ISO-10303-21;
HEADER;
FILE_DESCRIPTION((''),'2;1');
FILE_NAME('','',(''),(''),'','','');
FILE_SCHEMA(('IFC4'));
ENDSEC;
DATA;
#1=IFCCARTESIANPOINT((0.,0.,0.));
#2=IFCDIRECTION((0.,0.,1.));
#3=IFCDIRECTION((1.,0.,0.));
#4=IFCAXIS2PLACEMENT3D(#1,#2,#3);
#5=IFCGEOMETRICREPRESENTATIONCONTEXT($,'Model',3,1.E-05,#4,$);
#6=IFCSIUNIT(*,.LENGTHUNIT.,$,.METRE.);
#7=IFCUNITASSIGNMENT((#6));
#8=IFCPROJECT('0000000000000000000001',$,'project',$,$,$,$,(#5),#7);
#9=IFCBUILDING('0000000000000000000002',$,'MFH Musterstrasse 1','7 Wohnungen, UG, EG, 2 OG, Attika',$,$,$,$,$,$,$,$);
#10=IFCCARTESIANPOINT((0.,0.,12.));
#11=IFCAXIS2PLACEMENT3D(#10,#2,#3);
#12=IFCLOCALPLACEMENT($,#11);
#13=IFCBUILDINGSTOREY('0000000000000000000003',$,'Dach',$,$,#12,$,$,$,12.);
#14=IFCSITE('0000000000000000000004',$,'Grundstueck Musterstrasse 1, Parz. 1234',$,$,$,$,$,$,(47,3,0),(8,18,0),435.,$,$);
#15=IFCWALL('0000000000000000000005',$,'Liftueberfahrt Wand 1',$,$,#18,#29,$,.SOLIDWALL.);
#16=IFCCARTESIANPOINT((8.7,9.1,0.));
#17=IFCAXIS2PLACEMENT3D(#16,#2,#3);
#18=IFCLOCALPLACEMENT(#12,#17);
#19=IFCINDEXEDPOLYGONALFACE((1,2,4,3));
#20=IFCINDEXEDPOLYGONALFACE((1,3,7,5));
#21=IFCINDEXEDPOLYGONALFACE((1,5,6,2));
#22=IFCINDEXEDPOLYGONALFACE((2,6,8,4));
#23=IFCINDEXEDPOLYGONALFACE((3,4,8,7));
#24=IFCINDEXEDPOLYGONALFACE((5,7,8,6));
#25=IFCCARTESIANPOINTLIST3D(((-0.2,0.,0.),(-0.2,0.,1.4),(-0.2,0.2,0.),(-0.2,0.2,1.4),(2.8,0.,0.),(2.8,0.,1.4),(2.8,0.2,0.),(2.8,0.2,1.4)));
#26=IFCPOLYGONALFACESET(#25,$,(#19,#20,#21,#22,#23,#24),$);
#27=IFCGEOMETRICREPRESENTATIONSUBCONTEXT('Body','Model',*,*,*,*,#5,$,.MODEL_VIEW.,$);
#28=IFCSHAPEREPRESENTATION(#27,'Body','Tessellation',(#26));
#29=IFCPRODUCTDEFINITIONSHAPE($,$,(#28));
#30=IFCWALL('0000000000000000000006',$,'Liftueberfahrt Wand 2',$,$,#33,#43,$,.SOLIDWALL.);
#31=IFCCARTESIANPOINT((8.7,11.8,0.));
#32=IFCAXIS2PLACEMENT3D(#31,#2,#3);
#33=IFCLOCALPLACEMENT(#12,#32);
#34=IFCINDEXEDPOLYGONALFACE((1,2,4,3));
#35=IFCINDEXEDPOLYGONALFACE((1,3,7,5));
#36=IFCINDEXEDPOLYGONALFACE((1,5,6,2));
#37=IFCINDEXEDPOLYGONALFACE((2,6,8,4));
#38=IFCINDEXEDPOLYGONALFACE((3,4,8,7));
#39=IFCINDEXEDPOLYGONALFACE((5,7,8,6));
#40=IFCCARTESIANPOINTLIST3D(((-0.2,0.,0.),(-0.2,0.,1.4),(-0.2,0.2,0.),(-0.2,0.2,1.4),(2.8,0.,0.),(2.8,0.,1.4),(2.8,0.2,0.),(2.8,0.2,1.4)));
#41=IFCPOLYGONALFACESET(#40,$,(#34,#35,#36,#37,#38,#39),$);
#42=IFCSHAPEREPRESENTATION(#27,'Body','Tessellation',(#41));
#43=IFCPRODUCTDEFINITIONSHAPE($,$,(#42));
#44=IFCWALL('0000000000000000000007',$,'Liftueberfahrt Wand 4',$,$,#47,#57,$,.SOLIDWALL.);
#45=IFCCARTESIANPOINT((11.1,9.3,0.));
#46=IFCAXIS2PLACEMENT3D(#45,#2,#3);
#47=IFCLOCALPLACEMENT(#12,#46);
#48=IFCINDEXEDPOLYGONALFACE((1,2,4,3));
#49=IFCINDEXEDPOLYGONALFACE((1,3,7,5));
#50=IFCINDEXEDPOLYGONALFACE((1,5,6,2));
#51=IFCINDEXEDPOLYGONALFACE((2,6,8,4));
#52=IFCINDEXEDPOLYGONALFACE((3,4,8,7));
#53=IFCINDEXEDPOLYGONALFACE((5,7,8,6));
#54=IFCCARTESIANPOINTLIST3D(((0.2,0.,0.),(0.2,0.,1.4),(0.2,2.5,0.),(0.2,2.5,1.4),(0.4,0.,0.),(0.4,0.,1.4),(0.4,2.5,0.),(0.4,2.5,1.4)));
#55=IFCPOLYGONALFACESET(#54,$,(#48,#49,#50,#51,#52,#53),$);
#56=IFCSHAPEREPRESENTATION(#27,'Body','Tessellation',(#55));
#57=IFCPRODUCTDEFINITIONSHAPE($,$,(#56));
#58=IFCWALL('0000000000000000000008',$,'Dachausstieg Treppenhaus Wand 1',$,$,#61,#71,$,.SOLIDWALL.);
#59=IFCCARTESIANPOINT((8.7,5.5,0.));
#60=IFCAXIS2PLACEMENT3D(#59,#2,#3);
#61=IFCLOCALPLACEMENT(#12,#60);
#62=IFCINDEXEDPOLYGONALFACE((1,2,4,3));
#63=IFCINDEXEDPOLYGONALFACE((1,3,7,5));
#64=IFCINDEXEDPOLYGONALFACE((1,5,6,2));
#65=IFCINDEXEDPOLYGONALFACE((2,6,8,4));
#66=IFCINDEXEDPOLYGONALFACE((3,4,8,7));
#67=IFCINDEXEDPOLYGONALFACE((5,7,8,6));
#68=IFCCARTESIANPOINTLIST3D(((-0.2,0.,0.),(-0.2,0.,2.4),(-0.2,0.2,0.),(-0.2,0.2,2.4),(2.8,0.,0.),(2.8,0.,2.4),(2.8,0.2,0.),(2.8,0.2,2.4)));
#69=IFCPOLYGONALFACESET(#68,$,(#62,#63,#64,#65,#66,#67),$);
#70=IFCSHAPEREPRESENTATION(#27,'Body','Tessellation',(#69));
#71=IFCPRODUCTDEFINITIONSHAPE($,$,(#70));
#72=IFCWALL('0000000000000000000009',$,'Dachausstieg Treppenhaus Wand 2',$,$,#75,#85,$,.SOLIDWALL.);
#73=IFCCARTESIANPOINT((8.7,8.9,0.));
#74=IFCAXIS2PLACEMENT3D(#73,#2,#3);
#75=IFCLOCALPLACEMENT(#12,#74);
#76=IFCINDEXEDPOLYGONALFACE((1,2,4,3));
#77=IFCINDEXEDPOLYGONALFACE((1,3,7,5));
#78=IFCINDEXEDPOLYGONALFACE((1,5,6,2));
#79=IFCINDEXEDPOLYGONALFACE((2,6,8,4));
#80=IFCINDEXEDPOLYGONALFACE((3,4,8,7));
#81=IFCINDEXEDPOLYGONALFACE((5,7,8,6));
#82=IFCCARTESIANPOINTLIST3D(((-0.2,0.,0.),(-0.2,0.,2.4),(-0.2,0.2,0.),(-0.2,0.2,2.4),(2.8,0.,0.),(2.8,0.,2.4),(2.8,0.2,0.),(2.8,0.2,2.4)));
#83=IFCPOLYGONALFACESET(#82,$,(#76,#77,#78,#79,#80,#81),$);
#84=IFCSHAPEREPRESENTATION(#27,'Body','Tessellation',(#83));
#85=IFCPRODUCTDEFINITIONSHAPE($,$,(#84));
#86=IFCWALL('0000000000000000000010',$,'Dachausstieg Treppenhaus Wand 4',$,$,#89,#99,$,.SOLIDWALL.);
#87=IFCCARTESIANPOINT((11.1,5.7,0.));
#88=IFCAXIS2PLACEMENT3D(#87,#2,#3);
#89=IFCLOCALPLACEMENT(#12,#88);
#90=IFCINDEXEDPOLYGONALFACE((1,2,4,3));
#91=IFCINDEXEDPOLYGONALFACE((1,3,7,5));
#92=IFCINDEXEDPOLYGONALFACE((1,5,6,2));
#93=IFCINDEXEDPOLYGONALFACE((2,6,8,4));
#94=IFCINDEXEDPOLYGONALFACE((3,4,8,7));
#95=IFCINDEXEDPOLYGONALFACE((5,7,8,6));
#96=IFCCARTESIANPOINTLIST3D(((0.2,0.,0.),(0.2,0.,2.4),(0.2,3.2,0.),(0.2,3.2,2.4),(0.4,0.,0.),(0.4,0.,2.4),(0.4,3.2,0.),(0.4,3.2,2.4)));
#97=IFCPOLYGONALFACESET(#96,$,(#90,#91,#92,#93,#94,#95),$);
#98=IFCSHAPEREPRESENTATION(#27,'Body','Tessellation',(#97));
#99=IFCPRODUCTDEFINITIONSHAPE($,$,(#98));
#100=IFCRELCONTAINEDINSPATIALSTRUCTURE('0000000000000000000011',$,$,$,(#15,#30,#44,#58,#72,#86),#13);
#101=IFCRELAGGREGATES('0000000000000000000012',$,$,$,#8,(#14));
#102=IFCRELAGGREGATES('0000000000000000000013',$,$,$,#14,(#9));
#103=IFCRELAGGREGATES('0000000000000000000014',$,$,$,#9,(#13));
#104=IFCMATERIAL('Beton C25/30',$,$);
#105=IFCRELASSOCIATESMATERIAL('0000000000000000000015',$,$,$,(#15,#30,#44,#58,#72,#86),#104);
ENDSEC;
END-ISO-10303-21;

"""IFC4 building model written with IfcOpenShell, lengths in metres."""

from ifc_helpers import new_model, si_unit, frame, frame_2d, origin_with_axes, place, context, subcontext, project, spatial, rectangle, extrude, material, element, save


model = new_model("IFC4")

# Units and contexts
model_context = context("Model", 3, precision=1e-05, world=origin_with_axes())
body_context = subcontext(model_context, "Body", "Model", "MODEL_VIEW")
ifc_project = project(units=[si_unit("LENGTHUNIT", "METRE")], contexts=[model_context])

# Site, building, storey
site = spatial("IfcSite", under=ifc_project, Name="Grundstueck Musterstrasse 1, Parz. 1234", RefLatitude=(47, 3, 0), RefLongitude=(8, 18, 0), RefElevation=435.0)
building = spatial("IfcBuilding", under=site, Name="MFH Musterstrasse 1", Description="7 Wohnungen, UG, EG, 2 OG, Attika")
storey_placement = place(None, frame((0.0, 0.0, 12.0), z_axis=(0.0, 0.0, 1.0), x_axis=(1.0, 0.0, 0.0)))
storey = spatial("IfcBuildingStorey", under=building, at=storey_placement, Name="Dach", Elevation=12.0)

# Shared definitions
ifc_material_1 = material(Name="Beton C25/30")

# Walls
for number, where, z_axis, x_axis, name in (
    (1, (8.7, 9.1, 0.0), (0.0, 0.0, 1.0), (1.0, 0.0, 0.0), "Liftueberfahrt Wand 1"),
    (2, (8.7, 11.8, 0.0), (0.0, 0.0, 1.0), (1.0, 0.0, 0.0), "Liftueberfahrt Wand 2"),
):
    element("IfcWall", number, at=place(storey_placement, frame(where, z_axis=z_axis, x_axis=x_axis)), inside=storey, material=ifc_material_1, Name=name, PredefinedType="SOLIDWALL", context=body_context, shape_type="SweptSolid", body=[
        extrude(rectangle(XDim=3.0, YDim=0.2, at=frame_2d((1.3, 0.1))), origin_with_axes(), (0.0, 0.0, 1.0), 1.4),
    ])
wall_1_placement = place(storey_placement, frame((11.1, 9.3, 0.0), z_axis=(0.0, 0.0, 1.0), x_axis=(1.0, 0.0, 0.0)))
element("IfcWall", 3, at=wall_1_placement, inside=storey, material=ifc_material_1, Name="Liftueberfahrt Wand 4", PredefinedType="SOLIDWALL", context=body_context, shape_type="SweptSolid", body=[
    extrude(rectangle(XDim=0.2, YDim=2.5, at=frame_2d((0.3, 1.25))), origin_with_axes(), (0.0, 0.0, 1.0), 1.4),
])
for number, where, z_axis, x_axis, name in (
    (4, (8.7, 5.5, 0.0), (0.0, 0.0, 1.0), (1.0, 0.0, 0.0), "Dachausstieg Treppenhaus Wand 1"),
    (5, (8.7, 8.9, 0.0), (0.0, 0.0, 1.0), (1.0, 0.0, 0.0), "Dachausstieg Treppenhaus Wand 2"),
):
    element("IfcWall", number, at=place(storey_placement, frame(where, z_axis=z_axis, x_axis=x_axis)), inside=storey, material=ifc_material_1, Name=name, PredefinedType="SOLIDWALL", context=body_context, shape_type="SweptSolid", body=[
        extrude(rectangle(XDim=3.0, YDim=0.2, at=frame_2d((1.3, 0.1))), origin_with_axes(), (0.0, 0.0, 1.0), 2.4),
    ])
wall_2_placement = place(storey_placement, frame((11.1, 5.7, 0.0), z_axis=(0.0, 0.0, 1.0), x_axis=(1.0, 0.0, 0.0)))
element("IfcWall", 6, at=wall_2_placement, inside=storey, material=ifc_material_1, Name="Dachausstieg Treppenhaus Wand 4", PredefinedType="SOLIDWALL", context=body_context, shape_type="SweptSolid", body=[
    extrude(rectangle(XDim=0.2, YDim=3.2, at=frame_2d((0.3, 1.6))), origin_with_axes(), (0.0, 0.0, 1.0), 2.4),
])

save(model, "model.ifc")
